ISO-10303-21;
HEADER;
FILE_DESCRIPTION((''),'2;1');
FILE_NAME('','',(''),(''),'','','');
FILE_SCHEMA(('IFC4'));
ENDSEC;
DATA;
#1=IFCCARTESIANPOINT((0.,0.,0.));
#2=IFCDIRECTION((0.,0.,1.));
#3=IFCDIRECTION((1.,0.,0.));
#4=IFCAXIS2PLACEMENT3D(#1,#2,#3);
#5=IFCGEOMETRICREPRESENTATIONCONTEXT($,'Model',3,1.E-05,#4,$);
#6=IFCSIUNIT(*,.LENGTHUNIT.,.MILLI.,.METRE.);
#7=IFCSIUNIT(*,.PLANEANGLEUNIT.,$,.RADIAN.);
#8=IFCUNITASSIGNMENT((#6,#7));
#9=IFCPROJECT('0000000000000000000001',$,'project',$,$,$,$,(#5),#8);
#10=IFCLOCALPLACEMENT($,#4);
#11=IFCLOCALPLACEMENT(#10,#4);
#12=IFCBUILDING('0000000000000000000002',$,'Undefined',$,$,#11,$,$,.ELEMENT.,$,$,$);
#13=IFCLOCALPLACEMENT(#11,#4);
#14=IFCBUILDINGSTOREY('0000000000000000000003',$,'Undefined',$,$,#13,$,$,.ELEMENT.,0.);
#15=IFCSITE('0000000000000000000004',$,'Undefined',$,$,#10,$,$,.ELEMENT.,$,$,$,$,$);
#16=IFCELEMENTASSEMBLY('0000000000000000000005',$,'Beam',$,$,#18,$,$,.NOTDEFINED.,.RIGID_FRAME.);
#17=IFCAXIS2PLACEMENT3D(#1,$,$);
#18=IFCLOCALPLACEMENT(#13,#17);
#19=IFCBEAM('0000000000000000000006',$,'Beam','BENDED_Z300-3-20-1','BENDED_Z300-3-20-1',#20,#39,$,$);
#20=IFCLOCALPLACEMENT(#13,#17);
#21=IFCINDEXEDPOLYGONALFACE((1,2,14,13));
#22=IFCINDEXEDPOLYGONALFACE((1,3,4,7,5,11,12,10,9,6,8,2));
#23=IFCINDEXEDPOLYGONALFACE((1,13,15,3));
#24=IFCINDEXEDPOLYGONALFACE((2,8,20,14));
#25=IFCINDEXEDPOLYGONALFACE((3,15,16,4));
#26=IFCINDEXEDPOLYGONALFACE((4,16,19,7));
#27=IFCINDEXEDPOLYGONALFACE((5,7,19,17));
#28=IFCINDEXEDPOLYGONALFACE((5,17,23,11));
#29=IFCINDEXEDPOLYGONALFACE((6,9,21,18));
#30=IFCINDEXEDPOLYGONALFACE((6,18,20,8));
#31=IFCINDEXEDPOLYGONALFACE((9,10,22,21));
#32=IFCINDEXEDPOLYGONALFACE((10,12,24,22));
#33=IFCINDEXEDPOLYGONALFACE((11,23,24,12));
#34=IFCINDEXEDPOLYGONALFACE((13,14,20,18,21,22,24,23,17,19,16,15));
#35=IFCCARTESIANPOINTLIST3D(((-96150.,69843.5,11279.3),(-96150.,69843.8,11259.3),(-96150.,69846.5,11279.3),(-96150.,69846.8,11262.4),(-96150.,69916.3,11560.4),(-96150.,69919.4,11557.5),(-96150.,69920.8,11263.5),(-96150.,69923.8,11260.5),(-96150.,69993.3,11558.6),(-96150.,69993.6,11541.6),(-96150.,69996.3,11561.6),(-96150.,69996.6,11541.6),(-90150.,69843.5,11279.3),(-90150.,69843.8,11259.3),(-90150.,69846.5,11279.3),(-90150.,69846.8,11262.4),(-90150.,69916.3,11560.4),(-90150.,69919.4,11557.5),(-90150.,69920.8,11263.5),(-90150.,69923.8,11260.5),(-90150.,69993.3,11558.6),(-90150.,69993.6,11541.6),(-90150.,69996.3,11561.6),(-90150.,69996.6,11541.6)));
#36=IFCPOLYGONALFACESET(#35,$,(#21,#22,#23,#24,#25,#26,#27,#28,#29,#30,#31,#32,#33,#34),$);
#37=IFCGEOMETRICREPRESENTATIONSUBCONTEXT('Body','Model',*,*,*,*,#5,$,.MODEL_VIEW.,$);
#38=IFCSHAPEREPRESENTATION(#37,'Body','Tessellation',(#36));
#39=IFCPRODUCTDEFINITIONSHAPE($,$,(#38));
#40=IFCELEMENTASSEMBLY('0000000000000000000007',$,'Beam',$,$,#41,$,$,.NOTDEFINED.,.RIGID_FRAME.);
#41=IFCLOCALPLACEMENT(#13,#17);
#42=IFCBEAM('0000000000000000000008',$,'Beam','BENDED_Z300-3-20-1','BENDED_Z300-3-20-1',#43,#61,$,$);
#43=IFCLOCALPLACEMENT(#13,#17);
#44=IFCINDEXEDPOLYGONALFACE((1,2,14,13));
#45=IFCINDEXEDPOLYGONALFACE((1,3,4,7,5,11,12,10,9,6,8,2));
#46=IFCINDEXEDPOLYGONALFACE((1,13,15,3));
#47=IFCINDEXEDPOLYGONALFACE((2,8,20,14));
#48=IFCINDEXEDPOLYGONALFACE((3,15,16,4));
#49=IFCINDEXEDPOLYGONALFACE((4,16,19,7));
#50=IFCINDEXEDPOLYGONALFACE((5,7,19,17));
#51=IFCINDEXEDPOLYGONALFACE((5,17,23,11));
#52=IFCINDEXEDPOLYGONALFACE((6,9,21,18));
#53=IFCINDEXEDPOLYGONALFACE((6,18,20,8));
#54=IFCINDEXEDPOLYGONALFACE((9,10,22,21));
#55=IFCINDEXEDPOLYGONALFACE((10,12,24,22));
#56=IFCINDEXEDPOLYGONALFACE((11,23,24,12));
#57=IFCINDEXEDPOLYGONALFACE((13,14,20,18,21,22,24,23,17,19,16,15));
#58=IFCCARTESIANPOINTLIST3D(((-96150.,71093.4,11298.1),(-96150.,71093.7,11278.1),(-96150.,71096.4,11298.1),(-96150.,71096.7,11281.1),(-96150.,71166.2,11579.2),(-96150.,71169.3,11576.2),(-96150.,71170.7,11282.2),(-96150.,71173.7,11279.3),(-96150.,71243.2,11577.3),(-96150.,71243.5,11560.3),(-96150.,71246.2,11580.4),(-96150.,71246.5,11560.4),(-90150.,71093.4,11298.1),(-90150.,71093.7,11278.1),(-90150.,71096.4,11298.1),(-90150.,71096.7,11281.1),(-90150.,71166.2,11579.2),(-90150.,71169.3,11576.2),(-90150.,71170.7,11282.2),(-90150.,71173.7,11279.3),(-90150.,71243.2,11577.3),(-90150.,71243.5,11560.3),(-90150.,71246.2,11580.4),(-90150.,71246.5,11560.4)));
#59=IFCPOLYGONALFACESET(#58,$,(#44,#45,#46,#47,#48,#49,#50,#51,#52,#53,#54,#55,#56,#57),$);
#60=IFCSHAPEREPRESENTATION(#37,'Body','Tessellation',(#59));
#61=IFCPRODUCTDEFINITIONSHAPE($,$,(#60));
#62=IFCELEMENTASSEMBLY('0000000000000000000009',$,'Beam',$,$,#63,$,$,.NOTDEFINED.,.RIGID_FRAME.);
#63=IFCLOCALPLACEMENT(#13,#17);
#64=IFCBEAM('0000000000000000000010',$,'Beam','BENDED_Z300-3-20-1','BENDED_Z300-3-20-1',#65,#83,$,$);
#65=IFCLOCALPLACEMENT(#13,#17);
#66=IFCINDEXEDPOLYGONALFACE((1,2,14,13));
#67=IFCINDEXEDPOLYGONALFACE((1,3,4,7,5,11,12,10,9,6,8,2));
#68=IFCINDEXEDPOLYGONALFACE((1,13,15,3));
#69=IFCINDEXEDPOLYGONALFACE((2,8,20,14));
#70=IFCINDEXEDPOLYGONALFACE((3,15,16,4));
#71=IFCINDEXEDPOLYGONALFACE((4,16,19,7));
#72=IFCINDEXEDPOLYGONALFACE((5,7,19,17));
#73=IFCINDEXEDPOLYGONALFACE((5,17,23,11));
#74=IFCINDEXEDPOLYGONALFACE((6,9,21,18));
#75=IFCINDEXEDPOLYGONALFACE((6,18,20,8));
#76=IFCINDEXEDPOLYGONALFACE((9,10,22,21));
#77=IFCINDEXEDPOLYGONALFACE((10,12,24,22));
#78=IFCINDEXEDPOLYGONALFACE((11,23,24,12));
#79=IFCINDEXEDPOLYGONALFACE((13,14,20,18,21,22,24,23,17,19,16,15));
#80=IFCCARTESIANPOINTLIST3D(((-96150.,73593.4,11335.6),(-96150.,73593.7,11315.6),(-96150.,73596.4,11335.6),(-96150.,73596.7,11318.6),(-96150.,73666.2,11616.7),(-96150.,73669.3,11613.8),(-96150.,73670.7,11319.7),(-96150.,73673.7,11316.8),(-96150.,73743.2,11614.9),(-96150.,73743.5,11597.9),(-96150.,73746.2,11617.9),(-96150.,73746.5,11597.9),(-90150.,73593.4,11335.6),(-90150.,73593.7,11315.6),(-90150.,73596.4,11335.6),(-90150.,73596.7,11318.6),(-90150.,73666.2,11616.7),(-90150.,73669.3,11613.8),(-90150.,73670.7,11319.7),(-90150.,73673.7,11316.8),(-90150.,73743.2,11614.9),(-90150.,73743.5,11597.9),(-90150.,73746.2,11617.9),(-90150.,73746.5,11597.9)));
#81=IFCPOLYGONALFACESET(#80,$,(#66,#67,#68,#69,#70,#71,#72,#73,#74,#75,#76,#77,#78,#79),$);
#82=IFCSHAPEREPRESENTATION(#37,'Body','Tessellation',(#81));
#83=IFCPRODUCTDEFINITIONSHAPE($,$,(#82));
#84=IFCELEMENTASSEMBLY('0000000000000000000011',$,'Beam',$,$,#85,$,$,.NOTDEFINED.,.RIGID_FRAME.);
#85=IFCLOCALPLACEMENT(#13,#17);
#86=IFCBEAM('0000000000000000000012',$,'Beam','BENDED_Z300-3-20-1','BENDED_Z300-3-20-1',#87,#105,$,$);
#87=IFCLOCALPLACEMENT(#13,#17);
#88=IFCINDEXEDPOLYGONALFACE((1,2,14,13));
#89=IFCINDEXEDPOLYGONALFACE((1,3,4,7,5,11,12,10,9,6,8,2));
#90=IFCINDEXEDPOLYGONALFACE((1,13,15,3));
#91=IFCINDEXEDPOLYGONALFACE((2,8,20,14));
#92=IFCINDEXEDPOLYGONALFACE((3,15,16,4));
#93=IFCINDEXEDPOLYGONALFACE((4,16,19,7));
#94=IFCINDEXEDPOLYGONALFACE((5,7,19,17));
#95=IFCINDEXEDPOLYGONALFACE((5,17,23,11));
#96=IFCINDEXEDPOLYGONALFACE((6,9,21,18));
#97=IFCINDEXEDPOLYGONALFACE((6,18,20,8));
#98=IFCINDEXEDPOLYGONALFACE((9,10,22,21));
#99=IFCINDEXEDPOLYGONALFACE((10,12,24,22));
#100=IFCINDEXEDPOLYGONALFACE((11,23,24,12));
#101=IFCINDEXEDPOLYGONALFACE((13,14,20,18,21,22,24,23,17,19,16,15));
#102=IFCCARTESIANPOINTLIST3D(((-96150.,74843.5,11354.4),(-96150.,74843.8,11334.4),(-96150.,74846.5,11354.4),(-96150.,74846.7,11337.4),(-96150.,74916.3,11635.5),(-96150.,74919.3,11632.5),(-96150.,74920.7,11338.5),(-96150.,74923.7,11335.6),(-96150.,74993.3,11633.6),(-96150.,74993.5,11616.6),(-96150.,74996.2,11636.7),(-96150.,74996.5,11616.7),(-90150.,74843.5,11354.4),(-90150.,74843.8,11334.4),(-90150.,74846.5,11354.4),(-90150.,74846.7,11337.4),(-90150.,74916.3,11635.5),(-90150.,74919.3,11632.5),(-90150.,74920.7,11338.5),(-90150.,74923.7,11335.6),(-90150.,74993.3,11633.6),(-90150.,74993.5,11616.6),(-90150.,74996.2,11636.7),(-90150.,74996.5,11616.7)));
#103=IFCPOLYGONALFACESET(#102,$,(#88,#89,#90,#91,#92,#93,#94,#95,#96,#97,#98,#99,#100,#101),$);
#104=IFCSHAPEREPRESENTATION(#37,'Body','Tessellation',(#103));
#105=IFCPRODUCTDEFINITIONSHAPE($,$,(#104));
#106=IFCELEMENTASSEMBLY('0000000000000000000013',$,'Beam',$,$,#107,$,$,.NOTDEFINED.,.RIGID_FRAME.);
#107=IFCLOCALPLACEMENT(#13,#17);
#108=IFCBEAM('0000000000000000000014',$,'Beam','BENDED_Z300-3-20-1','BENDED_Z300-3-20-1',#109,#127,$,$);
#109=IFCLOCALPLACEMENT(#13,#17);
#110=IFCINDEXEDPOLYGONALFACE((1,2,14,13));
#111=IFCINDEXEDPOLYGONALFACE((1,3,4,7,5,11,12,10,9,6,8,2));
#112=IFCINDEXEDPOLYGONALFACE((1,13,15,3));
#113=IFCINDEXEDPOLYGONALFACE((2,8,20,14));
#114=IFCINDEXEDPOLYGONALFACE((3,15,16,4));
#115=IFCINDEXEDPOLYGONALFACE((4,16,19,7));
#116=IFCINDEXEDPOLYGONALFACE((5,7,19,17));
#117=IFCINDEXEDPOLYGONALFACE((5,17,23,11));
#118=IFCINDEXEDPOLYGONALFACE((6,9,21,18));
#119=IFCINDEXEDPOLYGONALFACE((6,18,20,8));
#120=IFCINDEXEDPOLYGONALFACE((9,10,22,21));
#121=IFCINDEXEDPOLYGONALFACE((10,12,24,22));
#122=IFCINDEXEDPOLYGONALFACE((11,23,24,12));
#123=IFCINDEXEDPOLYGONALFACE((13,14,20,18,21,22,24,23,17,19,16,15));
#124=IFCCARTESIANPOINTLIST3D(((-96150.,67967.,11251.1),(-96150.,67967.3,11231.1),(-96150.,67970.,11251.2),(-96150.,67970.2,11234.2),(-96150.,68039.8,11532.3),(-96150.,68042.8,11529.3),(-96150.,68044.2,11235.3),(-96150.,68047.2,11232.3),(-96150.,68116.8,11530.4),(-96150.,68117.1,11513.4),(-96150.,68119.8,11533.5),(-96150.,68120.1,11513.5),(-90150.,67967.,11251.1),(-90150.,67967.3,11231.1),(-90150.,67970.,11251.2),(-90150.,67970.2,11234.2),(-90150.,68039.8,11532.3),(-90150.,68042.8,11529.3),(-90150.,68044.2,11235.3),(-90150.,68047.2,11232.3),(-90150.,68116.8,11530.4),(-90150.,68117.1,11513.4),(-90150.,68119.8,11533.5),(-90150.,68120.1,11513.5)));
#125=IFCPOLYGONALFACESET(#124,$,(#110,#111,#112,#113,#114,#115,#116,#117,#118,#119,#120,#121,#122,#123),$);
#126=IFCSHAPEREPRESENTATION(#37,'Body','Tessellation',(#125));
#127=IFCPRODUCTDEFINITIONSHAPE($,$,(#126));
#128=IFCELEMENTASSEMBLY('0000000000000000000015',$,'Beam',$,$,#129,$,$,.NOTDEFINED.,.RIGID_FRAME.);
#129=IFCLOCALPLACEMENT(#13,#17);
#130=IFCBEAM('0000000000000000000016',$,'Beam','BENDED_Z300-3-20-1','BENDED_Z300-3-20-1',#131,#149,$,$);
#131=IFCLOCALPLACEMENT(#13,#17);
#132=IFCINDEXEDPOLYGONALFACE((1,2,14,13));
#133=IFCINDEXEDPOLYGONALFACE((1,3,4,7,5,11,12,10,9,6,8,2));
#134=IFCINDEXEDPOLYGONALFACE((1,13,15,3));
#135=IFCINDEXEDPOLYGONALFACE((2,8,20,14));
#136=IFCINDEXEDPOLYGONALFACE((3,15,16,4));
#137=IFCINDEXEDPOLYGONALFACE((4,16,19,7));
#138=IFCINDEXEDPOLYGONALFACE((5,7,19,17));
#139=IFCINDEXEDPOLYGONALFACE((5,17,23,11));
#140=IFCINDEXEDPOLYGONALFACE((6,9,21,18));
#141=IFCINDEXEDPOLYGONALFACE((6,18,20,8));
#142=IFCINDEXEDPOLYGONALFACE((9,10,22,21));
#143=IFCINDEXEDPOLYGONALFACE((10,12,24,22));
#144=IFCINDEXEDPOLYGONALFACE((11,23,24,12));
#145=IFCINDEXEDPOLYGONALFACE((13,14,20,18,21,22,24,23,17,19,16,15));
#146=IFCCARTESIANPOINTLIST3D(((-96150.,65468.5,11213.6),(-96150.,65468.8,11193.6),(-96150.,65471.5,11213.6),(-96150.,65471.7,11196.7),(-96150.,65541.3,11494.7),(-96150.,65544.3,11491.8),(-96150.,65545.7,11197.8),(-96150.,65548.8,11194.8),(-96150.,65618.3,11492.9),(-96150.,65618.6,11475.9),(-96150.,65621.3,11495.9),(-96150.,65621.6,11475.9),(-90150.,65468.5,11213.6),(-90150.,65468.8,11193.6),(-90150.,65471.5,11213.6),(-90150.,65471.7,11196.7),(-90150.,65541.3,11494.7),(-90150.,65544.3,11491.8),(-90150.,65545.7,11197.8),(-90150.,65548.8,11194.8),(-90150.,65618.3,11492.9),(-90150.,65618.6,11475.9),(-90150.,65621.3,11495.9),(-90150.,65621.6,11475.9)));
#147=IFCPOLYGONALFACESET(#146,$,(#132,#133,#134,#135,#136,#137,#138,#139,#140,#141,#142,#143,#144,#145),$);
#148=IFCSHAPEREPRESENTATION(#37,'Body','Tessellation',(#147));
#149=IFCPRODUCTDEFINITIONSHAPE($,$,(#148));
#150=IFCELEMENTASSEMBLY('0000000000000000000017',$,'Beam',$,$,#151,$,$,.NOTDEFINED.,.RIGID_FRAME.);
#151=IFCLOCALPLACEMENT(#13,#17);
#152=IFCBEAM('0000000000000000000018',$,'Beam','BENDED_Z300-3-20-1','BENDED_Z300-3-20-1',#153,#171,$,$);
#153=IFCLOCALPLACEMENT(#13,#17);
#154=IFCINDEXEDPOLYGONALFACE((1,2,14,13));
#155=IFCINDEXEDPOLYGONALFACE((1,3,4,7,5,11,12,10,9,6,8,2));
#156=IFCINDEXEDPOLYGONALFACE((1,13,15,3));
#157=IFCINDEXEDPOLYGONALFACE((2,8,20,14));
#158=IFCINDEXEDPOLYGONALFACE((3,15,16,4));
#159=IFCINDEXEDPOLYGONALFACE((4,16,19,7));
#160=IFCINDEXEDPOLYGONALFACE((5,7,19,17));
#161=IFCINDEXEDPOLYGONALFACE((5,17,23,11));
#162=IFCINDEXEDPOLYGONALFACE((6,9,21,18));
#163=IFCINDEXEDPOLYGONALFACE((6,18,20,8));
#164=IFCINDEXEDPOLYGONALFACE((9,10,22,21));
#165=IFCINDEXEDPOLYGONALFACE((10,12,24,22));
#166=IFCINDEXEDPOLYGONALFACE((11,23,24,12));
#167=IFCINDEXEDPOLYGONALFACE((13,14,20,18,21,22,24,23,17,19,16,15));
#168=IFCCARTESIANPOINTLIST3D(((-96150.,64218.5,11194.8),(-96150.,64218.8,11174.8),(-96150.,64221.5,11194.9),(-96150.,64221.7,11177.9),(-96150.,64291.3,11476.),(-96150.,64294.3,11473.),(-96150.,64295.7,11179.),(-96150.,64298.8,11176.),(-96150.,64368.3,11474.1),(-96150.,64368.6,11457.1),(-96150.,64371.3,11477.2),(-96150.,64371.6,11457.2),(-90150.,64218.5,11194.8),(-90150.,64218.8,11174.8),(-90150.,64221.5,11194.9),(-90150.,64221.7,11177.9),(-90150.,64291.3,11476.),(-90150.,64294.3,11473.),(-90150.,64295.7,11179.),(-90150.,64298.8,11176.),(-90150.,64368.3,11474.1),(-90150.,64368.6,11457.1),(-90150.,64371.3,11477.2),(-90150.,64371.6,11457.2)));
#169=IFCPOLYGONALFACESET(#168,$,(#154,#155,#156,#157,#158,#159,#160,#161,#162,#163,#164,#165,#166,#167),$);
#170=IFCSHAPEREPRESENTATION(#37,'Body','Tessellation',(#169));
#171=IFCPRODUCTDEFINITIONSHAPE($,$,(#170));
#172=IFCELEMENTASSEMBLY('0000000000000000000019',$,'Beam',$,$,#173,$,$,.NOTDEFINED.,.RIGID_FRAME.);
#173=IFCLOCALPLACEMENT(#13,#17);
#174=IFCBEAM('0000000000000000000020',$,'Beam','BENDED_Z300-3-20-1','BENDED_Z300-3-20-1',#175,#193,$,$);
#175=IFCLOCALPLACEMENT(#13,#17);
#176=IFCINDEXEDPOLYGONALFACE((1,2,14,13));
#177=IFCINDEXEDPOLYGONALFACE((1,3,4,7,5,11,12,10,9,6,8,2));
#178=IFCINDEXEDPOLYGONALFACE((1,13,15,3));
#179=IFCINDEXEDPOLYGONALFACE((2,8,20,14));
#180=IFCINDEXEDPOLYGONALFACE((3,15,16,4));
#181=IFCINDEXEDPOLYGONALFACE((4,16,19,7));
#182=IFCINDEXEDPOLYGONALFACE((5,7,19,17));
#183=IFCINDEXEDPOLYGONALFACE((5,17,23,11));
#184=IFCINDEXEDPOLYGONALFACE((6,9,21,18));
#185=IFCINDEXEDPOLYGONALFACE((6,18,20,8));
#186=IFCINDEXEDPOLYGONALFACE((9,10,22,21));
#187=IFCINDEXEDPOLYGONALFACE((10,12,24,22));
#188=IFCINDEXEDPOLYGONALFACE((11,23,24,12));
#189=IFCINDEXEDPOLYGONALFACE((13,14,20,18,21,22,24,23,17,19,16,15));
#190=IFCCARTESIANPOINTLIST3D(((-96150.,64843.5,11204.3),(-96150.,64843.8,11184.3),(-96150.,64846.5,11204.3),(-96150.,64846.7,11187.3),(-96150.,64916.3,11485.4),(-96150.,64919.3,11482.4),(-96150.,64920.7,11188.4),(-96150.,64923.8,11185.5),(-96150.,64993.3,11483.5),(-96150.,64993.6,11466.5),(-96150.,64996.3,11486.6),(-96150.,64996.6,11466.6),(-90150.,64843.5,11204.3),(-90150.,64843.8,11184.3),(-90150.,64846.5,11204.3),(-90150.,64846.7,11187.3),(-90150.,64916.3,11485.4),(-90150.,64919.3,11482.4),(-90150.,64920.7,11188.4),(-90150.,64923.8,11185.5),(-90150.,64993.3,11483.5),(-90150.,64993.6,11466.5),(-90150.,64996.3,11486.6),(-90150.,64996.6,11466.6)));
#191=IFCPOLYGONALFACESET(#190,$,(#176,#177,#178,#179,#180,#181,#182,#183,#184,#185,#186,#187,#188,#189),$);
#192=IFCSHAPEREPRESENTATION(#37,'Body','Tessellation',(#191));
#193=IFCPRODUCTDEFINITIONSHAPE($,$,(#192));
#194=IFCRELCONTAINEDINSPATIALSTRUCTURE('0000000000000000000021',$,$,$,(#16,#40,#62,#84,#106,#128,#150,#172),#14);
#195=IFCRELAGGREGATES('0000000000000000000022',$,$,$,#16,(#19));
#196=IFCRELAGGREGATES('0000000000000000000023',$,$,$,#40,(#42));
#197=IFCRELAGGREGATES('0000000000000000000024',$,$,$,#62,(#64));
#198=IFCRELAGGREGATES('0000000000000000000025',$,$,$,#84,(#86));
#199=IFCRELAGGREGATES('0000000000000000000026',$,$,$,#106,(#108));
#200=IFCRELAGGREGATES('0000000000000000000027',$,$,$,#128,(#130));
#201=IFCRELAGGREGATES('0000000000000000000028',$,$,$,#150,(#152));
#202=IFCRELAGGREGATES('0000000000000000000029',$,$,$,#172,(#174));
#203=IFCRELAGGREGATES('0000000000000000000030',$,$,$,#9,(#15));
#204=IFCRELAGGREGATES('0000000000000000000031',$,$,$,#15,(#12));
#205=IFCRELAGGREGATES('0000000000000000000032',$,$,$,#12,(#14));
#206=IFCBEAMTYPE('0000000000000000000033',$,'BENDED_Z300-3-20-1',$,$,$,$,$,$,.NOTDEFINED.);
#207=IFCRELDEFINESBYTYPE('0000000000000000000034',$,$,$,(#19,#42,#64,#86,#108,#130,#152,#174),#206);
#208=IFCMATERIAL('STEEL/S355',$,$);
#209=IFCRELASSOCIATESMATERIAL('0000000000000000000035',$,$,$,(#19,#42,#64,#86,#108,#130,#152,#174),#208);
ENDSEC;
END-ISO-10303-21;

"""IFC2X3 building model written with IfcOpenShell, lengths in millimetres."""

from ifc_helpers import new_model, si_unit, frame, origin_with_axes, place, context, subcontext, project, spatial, polyline, outline, extrude, material, type_object, element, aggregate, save


model = new_model("IFC2X3")

# Units and contexts
model_context = context("Model", 3, precision=1e-05, world=origin_with_axes())
body_context = subcontext(model_context, "Body", "Model", "MODEL_VIEW")
ifc_project = project(units=[si_unit("LENGTHUNIT", "METRE", prefix="MILLI"), si_unit("PLANEANGLEUNIT", "RADIAN")], contexts=[model_context])

# Site, building, storey
site_placement = place(None, origin_with_axes())
site = spatial("IfcSite", under=ifc_project, at=site_placement, Name="Undefined", CompositionType="ELEMENT")
building_placement = place(site_placement, origin_with_axes())
building = spatial("IfcBuilding", under=site, at=building_placement, Name="Undefined", CompositionType="ELEMENT")
storey_placement = place(building_placement, origin_with_axes())
storey = spatial("IfcBuildingStorey", under=building, at=storey_placement, Name="Undefined", CompositionType="ELEMENT", Elevation=0.0)

# Element assemblies, beams
ifc_material = material(Name="STEEL/S355")
beam_type_1 = type_object("IfcBeamType", Name="BENDED_Z300-3-20-1", PredefinedType="NOTDEFINED")
assembly_1_placement = place(storey_placement, origin_with_axes())
assembly_1 = element("IfcElementAssembly", 1, at=assembly_1_placement, inside=storey, Name="Beam", AssemblyPlace="NOTDEFINED", PredefinedType="RIGID_FRAME")
beam_1_placement = place(assembly_1_placement, frame((-90150.0, 69920.1, 11410.5), z_axis=(0.0, -0.014963, 0.999888), x_axis=(-1.0, 0.0, 0.0)))
beam_1 = element("IfcBeam", 2, at=beam_1_placement, type_object=beam_type_1, material=ifc_material, Name="Beam", Description="BENDED_Z300-3-20-1", ObjectType="BENDED_Z300-3-20-1", context=body_context, shape_type="SweptSolid", body=[
    extrude(outline(polyline([(1.5, -150.0), (-78.5, -150.0), (-78.5, -130.0), (-75.5, -130.0), (-75.5, -147.0), (-1.5, -147.0), (-1.5, 150.0), (78.5, 150.0), (78.5, 130.0), (75.5, 130.0), (75.5, 147.0), (1.5, 147.0), (1.5, -150.0)])), frame((6000.0, 0.0, 0.0), z_axis=(-1.0, 0.0, 0.0), x_axis=(0.0, -1.0, 0.0)), (0.0, 0.0, 1.0), 6000.0),
])
aggregate(assembly_1, [beam_1])
assembly_2_placement = place(storey_placement, origin_with_axes())
assembly_2 = element("IfcElementAssembly", 3, at=assembly_2_placement, inside=storey, Name="Beam", AssemblyPlace="NOTDEFINED", PredefinedType="RIGID_FRAME")
beam_2_placement = place(assembly_2_placement, frame((-90150.0, 71170.0, 11429.2), z_axis=(0.0, -0.014963, 0.999888), x_axis=(-1.0, 0.0, 0.0)))
beam_2 = element("IfcBeam", 4, at=beam_2_placement, type_object=beam_type_1, material=ifc_material, Name="Beam", Description="BENDED_Z300-3-20-1", ObjectType="BENDED_Z300-3-20-1", context=body_context, shape_type="SweptSolid", body=[
    extrude(outline(polyline([(1.5, -150.0), (-78.5, -150.0), (-78.5, -130.0), (-75.5, -130.0), (-75.5, -147.0), (-1.5, -147.0), (-1.5, 150.0), (78.5, 150.0), (78.5, 130.0), (75.5, 130.0), (75.5, 147.0), (1.5, 147.0), (1.5, -150.0)])), frame((6000.0, 0.0, 0.0), z_axis=(-1.0, 0.0, 0.0), x_axis=(0.0, -1.0, 0.0)), (0.0, 0.0, 1.0), 6000.0),
])
aggregate(assembly_2, [beam_2])
assembly_3_placement = place(storey_placement, origin_with_axes())
assembly_3 = element("IfcElementAssembly", 5, at=assembly_3_placement, inside=storey, Name="Beam", AssemblyPlace="NOTDEFINED", PredefinedType="RIGID_FRAME")
beam_3_placement = place(assembly_3_placement, frame((-90150.0, 73670.0, 11466.8), z_axis=(0.0, -0.014963, 0.999888), x_axis=(-1.0, 0.0, 0.0)))
beam_3 = element("IfcBeam", 6, at=beam_3_placement, type_object=beam_type_1, material=ifc_material, Name="Beam", Description="BENDED_Z300-3-20-1", ObjectType="BENDED_Z300-3-20-1", context=body_context, shape_type="SweptSolid", body=[
    extrude(outline(polyline([(1.5, -150.0), (-78.5, -150.0), (-78.5, -130.0), (-75.5, -130.0), (-75.5, -147.0), (-1.5, -147.0), (-1.5, 150.0), (78.5, 150.0), (78.5, 130.0), (75.5, 130.0), (75.5, 147.0), (1.5, 147.0), (1.5, -150.0)])), frame((6000.0, 0.0, 0.0), z_axis=(-1.0, 0.0, 0.0), x_axis=(0.0, -1.0, 0.0)), (0.0, 0.0, 1.0), 6000.0),
])
aggregate(assembly_3, [beam_3])
assembly_4_placement = place(storey_placement, origin_with_axes())
assembly_4 = element("IfcElementAssembly", 7, at=assembly_4_placement, inside=storey, Name="Beam", AssemblyPlace="NOTDEFINED", PredefinedType="RIGID_FRAME")
beam_4_placement = place(assembly_4_placement, frame((-90150.0, 74920.0, 11485.5), z_axis=(0.0, -0.014963, 0.999888), x_axis=(-1.0, 0.0, 0.0)))
beam_4 = element("IfcBeam", 8, at=beam_4_placement, type_object=beam_type_1, material=ifc_material, Name="Beam", Description="BENDED_Z300-3-20-1", ObjectType="BENDED_Z300-3-20-1", context=body_context, shape_type="SweptSolid", body=[
    extrude(outline(polyline([(1.5, -150.0), (-78.5, -150.0), (-78.5, -130.0), (-75.5, -130.0), (-75.5, -147.0), (-1.5, -147.0), (-1.5, 150.0), (78.5, 150.0), (78.5, 130.0), (75.5, 130.0), (75.5, 147.0), (1.5, 147.0), (1.5, -150.0)])), frame((6000.0, 0.0, 0.0), z_axis=(-1.0, 0.0, 0.0), x_axis=(0.0, -1.0, 0.0)), (0.0, 0.0, 1.0), 6000.0),
])
aggregate(assembly_4, [beam_4])
assembly_5_placement = place(storey_placement, origin_with_axes())
assembly_5 = element("IfcElementAssembly", 9, at=assembly_5_placement, inside=storey, Name="Beam", AssemblyPlace="NOTDEFINED", PredefinedType="RIGID_FRAME")
beam_5_placement = place(assembly_5_placement, frame((-90150.0, 68043.5, 11382.3), z_axis=(0.0, -0.014963, 0.999888), x_axis=(-1.0, 0.0, 0.0)))
beam_5 = element("IfcBeam", 10, at=beam_5_placement, type_object=beam_type_1, material=ifc_material, Name="Beam", Description="BENDED_Z300-3-20-1", ObjectType="BENDED_Z300-3-20-1", context=body_context, shape_type="SweptSolid", body=[
    extrude(outline(polyline([(1.5, -150.0), (-78.5, -150.0), (-78.5, -130.0), (-75.5, -130.0), (-75.5, -147.0), (-1.5, -147.0), (-1.5, 150.0), (78.5, 150.0), (78.5, 130.0), (75.5, 130.0), (75.5, 147.0), (1.5, 147.0), (1.5, -150.0)])), frame((6000.0, 0.0, 0.0), z_axis=(-1.0, 0.0, 0.0), x_axis=(0.0, -1.0, 0.0)), (0.0, 0.0, 1.0), 6000.0),
])
aggregate(assembly_5, [beam_5])
assembly_6_placement = place(storey_placement, origin_with_axes())
assembly_6 = element("IfcElementAssembly", 11, at=assembly_6_placement, inside=storey, Name="Beam", AssemblyPlace="NOTDEFINED", PredefinedType="RIGID_FRAME")
beam_6_placement = place(assembly_6_placement, frame((-90150.0, 65545.0, 11344.8), z_axis=(0.0, -0.014963, 0.999888), x_axis=(-1.0, 0.0, 0.0)))
beam_6 = element("IfcBeam", 12, at=beam_6_placement, type_object=beam_type_1, material=ifc_material, Name="Beam", Description="BENDED_Z300-3-20-1", ObjectType="BENDED_Z300-3-20-1", context=body_context, shape_type="SweptSolid", body=[
    extrude(outline(polyline([(1.5, -150.0), (-78.5, -150.0), (-78.5, -130.0), (-75.5, -130.0), (-75.5, -147.0), (-1.5, -147.0), (-1.5, 150.0), (78.5, 150.0), (78.5, 130.0), (75.5, 130.0), (75.5, 147.0), (1.5, 147.0), (1.5, -150.0)])), frame((6000.0, 0.0, 0.0), z_axis=(-1.0, 0.0, 0.0), x_axis=(0.0, -1.0, 0.0)), (0.0, 0.0, 1.0), 6000.0),
])
aggregate(assembly_6, [beam_6])
assembly_7_placement = place(storey_placement, origin_with_axes())
assembly_7 = element("IfcElementAssembly", 13, at=assembly_7_placement, inside=storey, Name="Beam", AssemblyPlace="NOTDEFINED", PredefinedType="RIGID_FRAME")
beam_7_placement = place(assembly_7_placement, frame((-90150.0, 64295.0, 11326.0), z_axis=(0.0, -0.014963, 0.999888), x_axis=(-1.0, 0.0, 0.0)))
beam_7 = element("IfcBeam", 14, at=beam_7_placement, type_object=beam_type_1, material=ifc_material, Name="Beam", Description="BENDED_Z300-3-20-1", ObjectType="BENDED_Z300-3-20-1", context=body_context, shape_type="SweptSolid", body=[
    extrude(outline(polyline([(1.5, -150.0), (-78.5, -150.0), (-78.5, -130.0), (-75.5, -130.0), (-75.5, -147.0), (-1.5, -147.0), (-1.5, 150.0), (78.5, 150.0), (78.5, 130.0), (75.5, 130.0), (75.5, 147.0), (1.5, 147.0), (1.5, -150.0)])), frame((6000.0, 0.0, 0.0), z_axis=(-1.0, 0.0, 0.0), x_axis=(0.0, -1.0, 0.0)), (0.0, 0.0, 1.0), 6000.0),
])
aggregate(assembly_7, [beam_7])
assembly_8_placement = place(storey_placement, origin_with_axes())
assembly_8 = element("IfcElementAssembly", 15, at=assembly_8_placement, inside=storey, Name="Beam", AssemblyPlace="NOTDEFINED", PredefinedType="RIGID_FRAME")
beam_8_placement = place(assembly_8_placement, frame((-90150.0, 64920.0, 11335.4), z_axis=(0.0, -0.014963, 0.999888), x_axis=(-1.0, 0.0, 0.0)))
beam_8 = element("IfcBeam", 16, at=beam_8_placement, type_object=beam_type_1, material=ifc_material, Name="Beam", Description="BENDED_Z300-3-20-1", ObjectType="BENDED_Z300-3-20-1", context=body_context, shape_type="SweptSolid", body=[
    extrude(outline(polyline([(1.5, -150.0), (-78.5, -150.0), (-78.5, -130.0), (-75.5, -130.0), (-75.5, -147.0), (-1.5, -147.0), (-1.5, 150.0), (78.5, 150.0), (78.5, 130.0), (75.5, 130.0), (75.5, 147.0), (1.5, 147.0), (1.5, -150.0)])), frame((6000.0, 0.0, 0.0), z_axis=(-1.0, 0.0, 0.0), x_axis=(0.0, -1.0, 0.0)), (0.0, 0.0, 1.0), 6000.0),
])
aggregate(assembly_8, [beam_8])

save(model, "model.ifc")
